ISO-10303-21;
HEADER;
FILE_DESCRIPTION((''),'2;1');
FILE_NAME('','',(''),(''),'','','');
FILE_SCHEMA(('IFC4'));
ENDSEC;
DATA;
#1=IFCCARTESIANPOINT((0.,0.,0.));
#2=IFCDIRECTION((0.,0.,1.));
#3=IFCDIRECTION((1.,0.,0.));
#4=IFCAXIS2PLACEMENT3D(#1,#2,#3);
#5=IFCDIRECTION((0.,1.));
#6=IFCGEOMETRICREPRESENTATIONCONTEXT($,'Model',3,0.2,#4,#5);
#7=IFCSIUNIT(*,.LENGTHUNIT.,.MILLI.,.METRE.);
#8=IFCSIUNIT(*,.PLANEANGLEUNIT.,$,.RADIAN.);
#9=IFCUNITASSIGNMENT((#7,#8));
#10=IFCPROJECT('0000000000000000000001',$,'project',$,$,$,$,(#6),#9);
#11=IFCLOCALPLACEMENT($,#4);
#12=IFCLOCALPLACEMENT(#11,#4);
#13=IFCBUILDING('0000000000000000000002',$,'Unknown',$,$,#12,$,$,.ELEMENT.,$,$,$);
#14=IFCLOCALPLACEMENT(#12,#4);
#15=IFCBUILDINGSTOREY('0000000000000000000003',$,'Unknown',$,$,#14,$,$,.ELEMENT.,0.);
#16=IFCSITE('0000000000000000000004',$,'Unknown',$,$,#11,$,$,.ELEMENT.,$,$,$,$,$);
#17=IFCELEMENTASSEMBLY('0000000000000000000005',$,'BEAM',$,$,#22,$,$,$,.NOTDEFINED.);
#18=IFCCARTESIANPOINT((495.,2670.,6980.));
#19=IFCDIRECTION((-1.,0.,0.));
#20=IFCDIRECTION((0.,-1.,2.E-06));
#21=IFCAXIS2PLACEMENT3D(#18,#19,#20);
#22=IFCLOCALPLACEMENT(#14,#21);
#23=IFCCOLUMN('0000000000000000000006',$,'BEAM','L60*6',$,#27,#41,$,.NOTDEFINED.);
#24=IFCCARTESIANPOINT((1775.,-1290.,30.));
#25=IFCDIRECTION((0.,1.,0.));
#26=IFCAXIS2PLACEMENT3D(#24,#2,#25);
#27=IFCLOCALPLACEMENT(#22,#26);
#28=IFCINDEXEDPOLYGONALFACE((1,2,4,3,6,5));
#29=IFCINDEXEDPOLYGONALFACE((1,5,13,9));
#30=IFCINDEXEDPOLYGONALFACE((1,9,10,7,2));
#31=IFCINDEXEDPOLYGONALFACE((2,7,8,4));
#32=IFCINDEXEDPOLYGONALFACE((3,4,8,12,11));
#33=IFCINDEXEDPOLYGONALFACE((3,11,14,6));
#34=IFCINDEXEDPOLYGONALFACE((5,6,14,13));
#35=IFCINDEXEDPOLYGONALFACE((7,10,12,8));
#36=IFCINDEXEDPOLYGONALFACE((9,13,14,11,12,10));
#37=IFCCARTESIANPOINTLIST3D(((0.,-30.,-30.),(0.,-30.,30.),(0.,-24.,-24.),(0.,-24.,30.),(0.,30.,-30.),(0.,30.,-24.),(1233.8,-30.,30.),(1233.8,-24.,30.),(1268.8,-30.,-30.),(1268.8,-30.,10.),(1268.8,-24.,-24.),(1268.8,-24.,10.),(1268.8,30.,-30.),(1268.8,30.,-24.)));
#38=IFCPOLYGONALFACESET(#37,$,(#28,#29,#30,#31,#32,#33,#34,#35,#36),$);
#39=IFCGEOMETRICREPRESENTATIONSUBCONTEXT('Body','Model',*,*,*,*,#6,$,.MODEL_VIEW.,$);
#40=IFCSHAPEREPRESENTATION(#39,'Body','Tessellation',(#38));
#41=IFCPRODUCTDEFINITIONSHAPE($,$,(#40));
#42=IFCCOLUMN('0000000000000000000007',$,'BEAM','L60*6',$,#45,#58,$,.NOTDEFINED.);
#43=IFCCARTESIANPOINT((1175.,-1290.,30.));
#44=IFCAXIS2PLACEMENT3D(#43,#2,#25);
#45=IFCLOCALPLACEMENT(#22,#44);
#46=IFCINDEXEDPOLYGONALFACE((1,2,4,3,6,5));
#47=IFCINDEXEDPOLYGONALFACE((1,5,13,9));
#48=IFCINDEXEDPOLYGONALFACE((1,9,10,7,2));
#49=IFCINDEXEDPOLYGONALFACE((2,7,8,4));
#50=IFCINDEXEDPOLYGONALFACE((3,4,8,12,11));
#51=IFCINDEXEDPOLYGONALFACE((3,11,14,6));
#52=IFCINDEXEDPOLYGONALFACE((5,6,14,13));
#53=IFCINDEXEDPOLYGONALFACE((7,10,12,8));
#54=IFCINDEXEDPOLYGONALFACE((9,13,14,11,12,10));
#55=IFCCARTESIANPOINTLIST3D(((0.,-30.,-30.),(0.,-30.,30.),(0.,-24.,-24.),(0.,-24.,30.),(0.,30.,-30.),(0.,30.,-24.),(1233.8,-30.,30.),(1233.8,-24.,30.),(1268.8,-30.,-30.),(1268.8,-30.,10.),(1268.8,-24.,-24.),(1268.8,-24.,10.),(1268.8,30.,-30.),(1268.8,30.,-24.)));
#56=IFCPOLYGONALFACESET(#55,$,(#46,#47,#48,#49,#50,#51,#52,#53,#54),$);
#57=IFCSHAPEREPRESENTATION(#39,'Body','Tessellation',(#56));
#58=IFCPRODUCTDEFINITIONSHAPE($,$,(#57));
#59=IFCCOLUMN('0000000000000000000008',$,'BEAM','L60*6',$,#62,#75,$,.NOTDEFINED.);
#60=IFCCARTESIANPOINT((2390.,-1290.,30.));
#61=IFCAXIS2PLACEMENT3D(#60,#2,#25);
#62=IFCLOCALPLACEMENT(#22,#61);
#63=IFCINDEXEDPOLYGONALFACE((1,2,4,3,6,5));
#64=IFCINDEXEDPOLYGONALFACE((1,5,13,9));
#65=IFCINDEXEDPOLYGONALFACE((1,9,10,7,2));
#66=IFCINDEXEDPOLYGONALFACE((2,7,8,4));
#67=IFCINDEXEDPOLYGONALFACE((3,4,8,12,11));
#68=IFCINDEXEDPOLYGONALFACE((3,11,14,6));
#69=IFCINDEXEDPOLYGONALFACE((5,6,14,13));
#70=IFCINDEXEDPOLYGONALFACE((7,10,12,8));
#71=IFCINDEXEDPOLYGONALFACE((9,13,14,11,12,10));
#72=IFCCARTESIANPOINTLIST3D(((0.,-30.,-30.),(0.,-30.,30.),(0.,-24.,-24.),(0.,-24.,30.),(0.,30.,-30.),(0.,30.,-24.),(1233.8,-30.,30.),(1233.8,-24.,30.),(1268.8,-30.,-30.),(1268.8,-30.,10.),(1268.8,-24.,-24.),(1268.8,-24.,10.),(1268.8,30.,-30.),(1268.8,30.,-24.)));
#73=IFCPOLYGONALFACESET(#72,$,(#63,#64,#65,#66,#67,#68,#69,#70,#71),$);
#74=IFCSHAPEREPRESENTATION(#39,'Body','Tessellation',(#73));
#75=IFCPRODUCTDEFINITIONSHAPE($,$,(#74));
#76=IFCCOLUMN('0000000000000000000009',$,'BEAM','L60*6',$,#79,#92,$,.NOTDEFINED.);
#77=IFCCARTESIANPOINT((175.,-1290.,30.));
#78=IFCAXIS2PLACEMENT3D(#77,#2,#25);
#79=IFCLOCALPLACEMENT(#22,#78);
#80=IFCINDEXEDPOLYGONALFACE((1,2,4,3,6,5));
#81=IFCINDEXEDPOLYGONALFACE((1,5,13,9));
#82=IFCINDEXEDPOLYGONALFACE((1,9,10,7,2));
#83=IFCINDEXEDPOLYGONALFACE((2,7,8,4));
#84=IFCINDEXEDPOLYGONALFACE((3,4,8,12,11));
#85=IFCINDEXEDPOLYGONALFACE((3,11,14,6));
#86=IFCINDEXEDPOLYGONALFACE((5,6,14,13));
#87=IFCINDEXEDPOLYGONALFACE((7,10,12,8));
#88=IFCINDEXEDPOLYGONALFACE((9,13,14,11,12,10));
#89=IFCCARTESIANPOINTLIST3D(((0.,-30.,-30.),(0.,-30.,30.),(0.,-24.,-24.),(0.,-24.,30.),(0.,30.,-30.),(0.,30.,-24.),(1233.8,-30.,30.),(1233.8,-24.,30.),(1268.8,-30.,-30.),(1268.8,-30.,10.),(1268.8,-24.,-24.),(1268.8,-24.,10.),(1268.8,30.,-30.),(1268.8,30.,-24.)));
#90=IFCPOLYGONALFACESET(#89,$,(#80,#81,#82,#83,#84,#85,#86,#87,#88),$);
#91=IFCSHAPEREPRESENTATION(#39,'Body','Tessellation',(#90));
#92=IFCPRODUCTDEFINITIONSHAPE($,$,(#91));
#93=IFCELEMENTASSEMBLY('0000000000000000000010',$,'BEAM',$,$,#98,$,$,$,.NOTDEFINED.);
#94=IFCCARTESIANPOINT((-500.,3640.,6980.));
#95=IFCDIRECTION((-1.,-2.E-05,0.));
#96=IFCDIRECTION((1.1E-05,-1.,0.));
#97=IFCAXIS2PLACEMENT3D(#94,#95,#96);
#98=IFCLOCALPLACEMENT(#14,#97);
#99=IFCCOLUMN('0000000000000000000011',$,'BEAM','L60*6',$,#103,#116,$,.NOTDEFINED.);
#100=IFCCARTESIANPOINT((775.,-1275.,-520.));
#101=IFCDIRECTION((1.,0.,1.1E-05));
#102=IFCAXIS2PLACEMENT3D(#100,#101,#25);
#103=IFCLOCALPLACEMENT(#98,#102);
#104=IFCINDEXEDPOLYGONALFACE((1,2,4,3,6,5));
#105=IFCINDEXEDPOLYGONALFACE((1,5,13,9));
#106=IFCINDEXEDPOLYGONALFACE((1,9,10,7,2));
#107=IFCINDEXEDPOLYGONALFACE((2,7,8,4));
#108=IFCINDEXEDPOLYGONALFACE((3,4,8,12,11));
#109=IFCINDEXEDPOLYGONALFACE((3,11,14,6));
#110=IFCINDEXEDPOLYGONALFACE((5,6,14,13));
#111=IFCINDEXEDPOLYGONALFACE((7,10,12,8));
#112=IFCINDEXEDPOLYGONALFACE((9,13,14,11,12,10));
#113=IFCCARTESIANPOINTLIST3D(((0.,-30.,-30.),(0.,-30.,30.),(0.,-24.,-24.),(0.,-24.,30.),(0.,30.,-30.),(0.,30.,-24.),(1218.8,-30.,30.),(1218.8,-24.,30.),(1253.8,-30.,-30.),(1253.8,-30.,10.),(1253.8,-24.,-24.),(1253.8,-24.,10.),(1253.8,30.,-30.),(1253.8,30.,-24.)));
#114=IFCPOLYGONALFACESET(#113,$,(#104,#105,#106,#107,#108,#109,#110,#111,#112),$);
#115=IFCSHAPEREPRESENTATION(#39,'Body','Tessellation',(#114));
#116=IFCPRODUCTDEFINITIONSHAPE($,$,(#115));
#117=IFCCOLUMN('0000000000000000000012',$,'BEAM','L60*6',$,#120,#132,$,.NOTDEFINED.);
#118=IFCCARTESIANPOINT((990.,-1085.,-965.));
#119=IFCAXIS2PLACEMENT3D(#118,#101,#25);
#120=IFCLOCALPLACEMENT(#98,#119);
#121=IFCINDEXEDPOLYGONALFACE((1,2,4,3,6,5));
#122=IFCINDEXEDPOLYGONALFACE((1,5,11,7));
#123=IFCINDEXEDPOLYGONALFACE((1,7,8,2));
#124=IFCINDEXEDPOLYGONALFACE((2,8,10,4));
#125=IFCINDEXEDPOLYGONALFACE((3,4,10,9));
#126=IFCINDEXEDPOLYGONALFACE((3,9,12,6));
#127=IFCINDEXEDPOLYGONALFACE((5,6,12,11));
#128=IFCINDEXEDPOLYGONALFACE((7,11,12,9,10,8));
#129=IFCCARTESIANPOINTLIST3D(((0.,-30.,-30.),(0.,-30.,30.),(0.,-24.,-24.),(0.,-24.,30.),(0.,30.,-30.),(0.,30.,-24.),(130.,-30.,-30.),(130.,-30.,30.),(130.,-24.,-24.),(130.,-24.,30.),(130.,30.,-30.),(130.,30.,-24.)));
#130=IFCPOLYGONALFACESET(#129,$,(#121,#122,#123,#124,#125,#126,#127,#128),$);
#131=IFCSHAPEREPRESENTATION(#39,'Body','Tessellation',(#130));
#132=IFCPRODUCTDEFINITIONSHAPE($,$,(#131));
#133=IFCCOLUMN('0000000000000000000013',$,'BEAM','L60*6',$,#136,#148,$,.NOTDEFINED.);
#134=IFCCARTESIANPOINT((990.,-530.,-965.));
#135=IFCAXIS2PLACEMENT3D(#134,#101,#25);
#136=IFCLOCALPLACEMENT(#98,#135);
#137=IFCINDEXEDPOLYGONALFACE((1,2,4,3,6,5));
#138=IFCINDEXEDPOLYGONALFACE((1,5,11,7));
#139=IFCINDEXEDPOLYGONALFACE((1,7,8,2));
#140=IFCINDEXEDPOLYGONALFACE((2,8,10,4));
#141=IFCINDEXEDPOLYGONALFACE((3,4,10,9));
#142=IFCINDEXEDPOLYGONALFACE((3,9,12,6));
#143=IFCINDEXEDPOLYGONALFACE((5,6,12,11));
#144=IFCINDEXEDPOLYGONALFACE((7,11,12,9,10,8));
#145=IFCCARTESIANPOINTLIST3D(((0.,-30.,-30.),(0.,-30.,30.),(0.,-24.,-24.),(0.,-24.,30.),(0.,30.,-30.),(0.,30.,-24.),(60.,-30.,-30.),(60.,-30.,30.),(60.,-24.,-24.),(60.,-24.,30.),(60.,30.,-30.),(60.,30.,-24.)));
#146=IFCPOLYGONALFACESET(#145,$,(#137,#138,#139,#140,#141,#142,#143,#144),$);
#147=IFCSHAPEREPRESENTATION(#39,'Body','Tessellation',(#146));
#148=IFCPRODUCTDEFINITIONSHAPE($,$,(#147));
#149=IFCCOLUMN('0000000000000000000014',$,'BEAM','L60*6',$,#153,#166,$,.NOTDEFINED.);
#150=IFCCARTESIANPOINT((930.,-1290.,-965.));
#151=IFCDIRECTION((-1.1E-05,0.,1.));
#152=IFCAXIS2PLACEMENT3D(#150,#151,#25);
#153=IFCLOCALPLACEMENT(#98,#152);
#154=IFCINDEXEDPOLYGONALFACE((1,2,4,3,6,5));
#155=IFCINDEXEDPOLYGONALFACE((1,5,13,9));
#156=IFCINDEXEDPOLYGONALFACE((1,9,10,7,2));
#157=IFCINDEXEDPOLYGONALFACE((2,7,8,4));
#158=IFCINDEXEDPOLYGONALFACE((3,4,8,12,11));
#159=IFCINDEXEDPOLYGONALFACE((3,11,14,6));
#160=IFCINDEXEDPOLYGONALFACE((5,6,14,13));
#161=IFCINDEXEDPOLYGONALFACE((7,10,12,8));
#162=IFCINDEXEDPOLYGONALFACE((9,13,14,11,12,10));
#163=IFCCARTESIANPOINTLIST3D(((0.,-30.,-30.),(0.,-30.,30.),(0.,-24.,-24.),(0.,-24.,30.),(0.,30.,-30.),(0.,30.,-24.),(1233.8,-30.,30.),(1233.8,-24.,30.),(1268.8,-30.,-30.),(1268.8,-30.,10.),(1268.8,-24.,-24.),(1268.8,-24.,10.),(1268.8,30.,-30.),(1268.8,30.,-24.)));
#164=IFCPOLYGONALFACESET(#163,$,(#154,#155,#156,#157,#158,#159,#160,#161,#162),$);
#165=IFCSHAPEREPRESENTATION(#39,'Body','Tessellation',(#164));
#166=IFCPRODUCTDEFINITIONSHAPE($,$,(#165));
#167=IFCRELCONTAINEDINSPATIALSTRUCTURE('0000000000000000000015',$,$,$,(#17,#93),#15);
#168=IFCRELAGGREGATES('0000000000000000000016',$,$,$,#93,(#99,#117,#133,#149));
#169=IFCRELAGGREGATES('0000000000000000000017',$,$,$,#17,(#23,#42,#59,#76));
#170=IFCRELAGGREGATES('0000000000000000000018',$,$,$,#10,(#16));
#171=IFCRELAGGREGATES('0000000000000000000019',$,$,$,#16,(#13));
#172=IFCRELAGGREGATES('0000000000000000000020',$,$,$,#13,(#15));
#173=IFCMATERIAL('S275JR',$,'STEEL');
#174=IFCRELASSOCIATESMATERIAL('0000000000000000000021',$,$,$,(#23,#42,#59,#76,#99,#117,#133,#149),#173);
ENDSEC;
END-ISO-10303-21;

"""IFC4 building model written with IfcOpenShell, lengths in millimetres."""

from ifc_helpers import new_model, si_unit, direction, frame, origin_with_axes, place, context, subcontext, project, spatial, line, indexed_curve, outline, extrude, material, element, aggregate, save


model = new_model("IFC4")

# Units and contexts
model_context = context("Model", 3, precision=0.2, world=origin_with_axes(), true_north=direction((0.0, 1.0)))
body_context = subcontext(model_context, "Body", "Model", "MODEL_VIEW")
ifc_project = project(units=[si_unit("LENGTHUNIT", "METRE", prefix="MILLI"), si_unit("PLANEANGLEUNIT", "RADIAN")], contexts=[model_context])

# Site, building, storey
site_placement = place(None, origin_with_axes())
site = spatial("IfcSite", under=ifc_project, at=site_placement, Name="Unknown", CompositionType="ELEMENT")
building_placement = place(site_placement, origin_with_axes())
building = spatial("IfcBuilding", under=site, at=building_placement, Name="Unknown", CompositionType="ELEMENT")
storey_placement = place(building_placement, origin_with_axes())
storey = spatial("IfcBuildingStorey", under=building, at=storey_placement, Name="Unknown", CompositionType="ELEMENT", Elevation=0.0)

# Element assemblies, columns, voiding features
assembly_1_placement = place(storey_placement, frame((495.0, 2670.0, 6980.0), z_axis=(-1.0, 0.0, 0.0), x_axis=(0.0, -1.0, 0.000002)))
assembly_1 = element("IfcElementAssembly", 1, at=assembly_1_placement, inside=storey, Name="BEAM", PredefinedType="NOTDEFINED")
ifc_material_1 = material(Name="S275JR", Category="STEEL")
column_1_placement = place(assembly_1_placement, frame((1775.0, -1290.0, 30.0), z_axis=(0.0, 0.0, 1.0), x_axis=(0.0, 1.0, 0.0)))
column_1 = element("IfcColumn", 2, at=column_1_placement, material=ifc_material_1, Name="BEAM", Description="L60*6", PredefinedType="NOTDEFINED", context=body_context, shape_type="SolidModel", body=[
    extrude(outline(indexed_curve([(-30.0, -30.0), (30.0, -30.0), (30.0, -24.0), (-24.0, -24.0), (-24.0, 30.0), (-30.0, 30.0)], segments=[line(1, 2, 3, 4, 5, 6, 1)])), frame((0.0, 0.0, 0.0), z_axis=(-1.0, 0.0, 0.0), x_axis=(0.0, 0.0, 1.0)), (0.0, -0.000002, -1.0), 1268.8),
])
voiding_feature_1_placement = place(column_1_placement, frame((1268.8, 0.0, 10.0), z_axis=(0.0, -1.0, 0.000002), x_axis=(0.0, 0.0, 1.0)))
element("IfcVoidingFeature", 3, at=voiding_feature_1_placement, cuts=column_1, Name="CUTPART", PredefinedType="HOLE", context=body_context, shape_type="SolidModel", body=[
    extrude(outline(indexed_curve([(0.0, 0.0), (20.0, 0.0), (20.0, 35.0)], segments=[line(1, 2, 3, 1)])), frame((0.0, 0.0, 33.0), z_axis=(0.0, 0.0, 1.0), x_axis=(1.0, 0.0, 0.0)), (0.0, -0.000002, -1.0), 66.0),
])
column_2_placement = place(assembly_1_placement, frame((1175.0, -1290.0, 30.0), z_axis=(0.0, 0.0, 1.0), x_axis=(0.0, 1.0, 0.0)))
column_2 = element("IfcColumn", 4, at=column_2_placement, material=ifc_material_1, Name="BEAM", Description="L60*6", PredefinedType="NOTDEFINED", context=body_context, shape_type="SolidModel", body=[
    extrude(outline(indexed_curve([(-30.0, -30.0), (30.0, -30.0), (30.0, -24.0), (-24.0, -24.0), (-24.0, 30.0), (-30.0, 30.0)], segments=[line(1, 2, 3, 4, 5, 6, 1)])), frame((0.0, 0.0, 0.0), z_axis=(-1.0, 0.0, 0.0), x_axis=(0.0, 0.0, 1.0)), (0.0, -0.000002, -1.0), 1268.8),
])
voiding_feature_2_placement = place(column_2_placement, frame((1268.8, 0.0, 10.0), z_axis=(0.0, -1.0, 0.000002), x_axis=(0.0, 0.0, 1.0)))
element("IfcVoidingFeature", 5, at=voiding_feature_2_placement, cuts=column_2, Name="CUTPART", PredefinedType="HOLE", context=body_context, shape_type="SolidModel", body=[
    extrude(outline(indexed_curve([(0.0, 0.0), (20.0, 0.0), (20.0, 35.0)], segments=[line(1, 2, 3, 1)])), frame((0.0, 0.0, 33.0), z_axis=(0.0, 0.0, 1.0), x_axis=(1.0, 0.0, 0.0)), (0.0, -0.000002, -1.0), 66.0),
])
column_3_placement = place(assembly_1_placement, frame((2390.0, -1290.0, 30.0), z_axis=(0.0, 0.0, 1.0), x_axis=(0.0, 1.0, 0.0)))
column_3 = element("IfcColumn", 6, at=column_3_placement, material=ifc_material_1, Name="BEAM", Description="L60*6", PredefinedType="NOTDEFINED", context=body_context, shape_type="SolidModel", body=[
    extrude(outline(indexed_curve([(-30.0, -30.0), (30.0, -30.0), (30.0, -24.0), (-24.0, -24.0), (-24.0, 30.0), (-30.0, 30.0)], segments=[line(1, 2, 3, 4, 5, 6, 1)])), frame((0.0, 0.0, 0.0), z_axis=(-1.0, 0.0, 0.0), x_axis=(0.0, 0.0, 1.0)), (0.0, -0.000002, -1.0), 1268.8),
])
voiding_feature_3_placement = place(column_3_placement, frame((1268.8, 0.0, 10.0), z_axis=(0.0, -1.0, 0.000002), x_axis=(0.0, 0.0, 1.0)))
element("IfcVoidingFeature", 7, at=voiding_feature_3_placement, cuts=column_3, Name="CUTPART", PredefinedType="HOLE", context=body_context, shape_type="SolidModel", body=[
    extrude(outline(indexed_curve([(0.0, 0.0), (20.0, 0.0), (20.0, 35.0)], segments=[line(1, 2, 3, 1)])), frame((0.0, 0.0, 33.0), z_axis=(0.0, 0.0, 1.0), x_axis=(1.0, 0.0, 0.0)), (0.0, -0.000002, -1.0), 66.0),
])
column_4_placement = place(assembly_1_placement, frame((175.0, -1290.0, 30.0), z_axis=(0.0, 0.0, 1.0), x_axis=(0.0, 1.0, 0.0)))
column_4 = element("IfcColumn", 8, at=column_4_placement, material=ifc_material_1, Name="BEAM", Description="L60*6", PredefinedType="NOTDEFINED", context=body_context, shape_type="SolidModel", body=[
    extrude(outline(indexed_curve([(-30.0, -30.0), (30.0, -30.0), (30.0, -24.0), (-24.0, -24.0), (-24.0, 30.0), (-30.0, 30.0)], segments=[line(1, 2, 3, 4, 5, 6, 1)])), frame((0.0, 0.0, 0.0), z_axis=(-1.0, 0.0, 0.0), x_axis=(0.0, 0.0, 1.0)), (0.0, -0.000002, -1.0), 1268.8),
])
voiding_feature_4_placement = place(column_4_placement, frame((1268.8, 0.0, 10.0), z_axis=(0.0, -1.0, 0.000002), x_axis=(0.0, 0.0, 1.0)))
element("IfcVoidingFeature", 9, at=voiding_feature_4_placement, cuts=column_4, Name="CUTPART", PredefinedType="HOLE", context=body_context, shape_type="SolidModel", body=[
    extrude(outline(indexed_curve([(0.0, 0.0), (20.0, 0.0), (20.0, 35.0)], segments=[line(1, 2, 3, 1)])), frame((0.0, 0.0, 33.0), z_axis=(0.0, 0.0, 1.0), x_axis=(1.0, 0.0, 0.0)), (0.0, -0.000002, -1.0), 66.0),
])
assembly_2_placement = place(storey_placement, frame((-500.0, 3640.0, 6980.0), z_axis=(-1.0, -0.00002, 0.0), x_axis=(0.000011, -1.0, 0.0)))
assembly_2 = element("IfcElementAssembly", 10, at=assembly_2_placement, inside=storey, Name="BEAM", PredefinedType="NOTDEFINED")
column_5_placement = place(assembly_2_placement, frame((775.0, -1275.0, -520.0), z_axis=(1.0, 0.0, 0.000011), x_axis=(0.0, 1.0, 0.0)))
column_5 = element("IfcColumn", 11, at=column_5_placement, material=ifc_material_1, Name="BEAM", Description="L60*6", PredefinedType="NOTDEFINED", context=body_context, shape_type="SolidModel", body=[
    extrude(outline(indexed_curve([(-30.0, -30.0), (30.0, -30.0), (30.0, -24.0), (-24.0, -24.0), (-24.0, 30.0), (-30.0, 30.0)], segments=[line(1, 2, 3, 4, 5, 6, 1)])), frame((0.0, 0.0, 0.0), z_axis=(-1.0, 0.0, 0.0), x_axis=(0.0, 0.0, 1.0)), (0.0, -0.000002, -1.0), 1253.8),
])
voiding_feature_5_placement = place(column_5_placement, frame((1253.8, 0.0, 10.0), z_axis=(0.0, -1.0, 0.000002), x_axis=(0.0, 0.0, 1.0)))
element("IfcVoidingFeature", 12, at=voiding_feature_5_placement, cuts=column_5, Name="CUTPART", PredefinedType="HOLE", context=body_context, shape_type="SolidModel", body=[
    extrude(outline(indexed_curve([(0.0, 0.0), (20.0, 0.0), (20.0, 35.0)], segments=[line(1, 2, 3, 1)])), frame((0.0, 0.0, 33.0), z_axis=(0.0, 0.0, 1.0), x_axis=(1.0, 0.0, 0.0)), (0.0, -0.000002, -1.0), 66.0),
])
column_6_placement = place(assembly_2_placement, frame((990.0, -1085.0, -965.0), z_axis=(1.0, 0.0, 0.000011), x_axis=(0.0, 1.0, 0.0)))
column_6 = element("IfcColumn", 13, at=column_6_placement, material=ifc_material_1, Name="BEAM", Description="L60*6", PredefinedType="NOTDEFINED", context=body_context, shape_type="SolidModel", body=[
    extrude(outline(indexed_curve([(-30.0, -30.0), (30.0, -30.0), (30.0, -24.0), (-24.0, -24.0), (-24.0, 30.0), (-30.0, 30.0)], segments=[line(1, 2, 3, 4, 5, 6, 1)])), frame((0.0, 0.0, 0.0), z_axis=(-1.0, 0.0, 0.0), x_axis=(0.0, 0.0, 1.0)), (0.0, -0.000002, -1.0), 130.0),
])
column_7_placement = place(assembly_2_placement, frame((990.0, -530.0, -965.0), z_axis=(1.0, 0.0, 0.000011), x_axis=(0.0, 1.0, 0.0)))
column_7 = element("IfcColumn", 14, at=column_7_placement, material=ifc_material_1, Name="BEAM", Description="L60*6", PredefinedType="NOTDEFINED", context=body_context, shape_type="SolidModel", body=[
    extrude(outline(indexed_curve([(-30.0, -30.0), (30.0, -30.0), (30.0, -24.0), (-24.0, -24.0), (-24.0, 30.0), (-30.0, 30.0)], segments=[line(1, 2, 3, 4, 5, 6, 1)])), frame((0.0, 0.0, 0.0), z_axis=(-1.0, 0.0, 0.0), x_axis=(0.0, 0.0, 1.0)), (0.0, -0.000002, -1.0), 60.0),
])
column_8_placement = place(assembly_2_placement, frame((930.0, -1290.0, -965.0), z_axis=(-0.000011, 0.0, 1.0), x_axis=(0.0, 1.0, 0.0)))
column_8 = element("IfcColumn", 15, at=column_8_placement, material=ifc_material_1, Name="BEAM", Description="L60*6", PredefinedType="NOTDEFINED", context=body_context, shape_type="SolidModel", body=[
    extrude(outline(indexed_curve([(-30.0, -30.0), (30.0, -30.0), (30.0, -24.0), (-24.0, -24.0), (-24.0, 30.0), (-30.0, 30.0)], segments=[line(1, 2, 3, 4, 5, 6, 1)])), frame((0.0, 0.0, 0.0), z_axis=(-1.0, 0.0, 0.0), x_axis=(0.0, 0.0, 1.0)), (0.0, -0.000002, -1.0), 1268.8),
])
voiding_feature_6_placement = place(column_8_placement, frame((1268.8, 0.0, 10.0), z_axis=(0.0, -1.0, 0.000002), x_axis=(0.0, 0.0, 1.0)))
element("IfcVoidingFeature", 16, at=voiding_feature_6_placement, cuts=column_8, Name="CUTPART", PredefinedType="HOLE", context=body_context, shape_type="SolidModel", body=[
    extrude(outline(indexed_curve([(0.0, 0.0), (20.0, 0.0), (20.0, 35.0)], segments=[line(1, 2, 3, 1)])), frame((0.0, 0.0, 33.0), z_axis=(0.0, 0.0, 1.0), x_axis=(1.0, 0.0, 0.0)), (0.0, -0.000002, -1.0), 66.0),
])

aggregate(assembly_2, [column_5, column_6, column_7, column_8])
aggregate(assembly_1, [column_1, column_2, column_3, column_4])

save(model, "model.ifc")
